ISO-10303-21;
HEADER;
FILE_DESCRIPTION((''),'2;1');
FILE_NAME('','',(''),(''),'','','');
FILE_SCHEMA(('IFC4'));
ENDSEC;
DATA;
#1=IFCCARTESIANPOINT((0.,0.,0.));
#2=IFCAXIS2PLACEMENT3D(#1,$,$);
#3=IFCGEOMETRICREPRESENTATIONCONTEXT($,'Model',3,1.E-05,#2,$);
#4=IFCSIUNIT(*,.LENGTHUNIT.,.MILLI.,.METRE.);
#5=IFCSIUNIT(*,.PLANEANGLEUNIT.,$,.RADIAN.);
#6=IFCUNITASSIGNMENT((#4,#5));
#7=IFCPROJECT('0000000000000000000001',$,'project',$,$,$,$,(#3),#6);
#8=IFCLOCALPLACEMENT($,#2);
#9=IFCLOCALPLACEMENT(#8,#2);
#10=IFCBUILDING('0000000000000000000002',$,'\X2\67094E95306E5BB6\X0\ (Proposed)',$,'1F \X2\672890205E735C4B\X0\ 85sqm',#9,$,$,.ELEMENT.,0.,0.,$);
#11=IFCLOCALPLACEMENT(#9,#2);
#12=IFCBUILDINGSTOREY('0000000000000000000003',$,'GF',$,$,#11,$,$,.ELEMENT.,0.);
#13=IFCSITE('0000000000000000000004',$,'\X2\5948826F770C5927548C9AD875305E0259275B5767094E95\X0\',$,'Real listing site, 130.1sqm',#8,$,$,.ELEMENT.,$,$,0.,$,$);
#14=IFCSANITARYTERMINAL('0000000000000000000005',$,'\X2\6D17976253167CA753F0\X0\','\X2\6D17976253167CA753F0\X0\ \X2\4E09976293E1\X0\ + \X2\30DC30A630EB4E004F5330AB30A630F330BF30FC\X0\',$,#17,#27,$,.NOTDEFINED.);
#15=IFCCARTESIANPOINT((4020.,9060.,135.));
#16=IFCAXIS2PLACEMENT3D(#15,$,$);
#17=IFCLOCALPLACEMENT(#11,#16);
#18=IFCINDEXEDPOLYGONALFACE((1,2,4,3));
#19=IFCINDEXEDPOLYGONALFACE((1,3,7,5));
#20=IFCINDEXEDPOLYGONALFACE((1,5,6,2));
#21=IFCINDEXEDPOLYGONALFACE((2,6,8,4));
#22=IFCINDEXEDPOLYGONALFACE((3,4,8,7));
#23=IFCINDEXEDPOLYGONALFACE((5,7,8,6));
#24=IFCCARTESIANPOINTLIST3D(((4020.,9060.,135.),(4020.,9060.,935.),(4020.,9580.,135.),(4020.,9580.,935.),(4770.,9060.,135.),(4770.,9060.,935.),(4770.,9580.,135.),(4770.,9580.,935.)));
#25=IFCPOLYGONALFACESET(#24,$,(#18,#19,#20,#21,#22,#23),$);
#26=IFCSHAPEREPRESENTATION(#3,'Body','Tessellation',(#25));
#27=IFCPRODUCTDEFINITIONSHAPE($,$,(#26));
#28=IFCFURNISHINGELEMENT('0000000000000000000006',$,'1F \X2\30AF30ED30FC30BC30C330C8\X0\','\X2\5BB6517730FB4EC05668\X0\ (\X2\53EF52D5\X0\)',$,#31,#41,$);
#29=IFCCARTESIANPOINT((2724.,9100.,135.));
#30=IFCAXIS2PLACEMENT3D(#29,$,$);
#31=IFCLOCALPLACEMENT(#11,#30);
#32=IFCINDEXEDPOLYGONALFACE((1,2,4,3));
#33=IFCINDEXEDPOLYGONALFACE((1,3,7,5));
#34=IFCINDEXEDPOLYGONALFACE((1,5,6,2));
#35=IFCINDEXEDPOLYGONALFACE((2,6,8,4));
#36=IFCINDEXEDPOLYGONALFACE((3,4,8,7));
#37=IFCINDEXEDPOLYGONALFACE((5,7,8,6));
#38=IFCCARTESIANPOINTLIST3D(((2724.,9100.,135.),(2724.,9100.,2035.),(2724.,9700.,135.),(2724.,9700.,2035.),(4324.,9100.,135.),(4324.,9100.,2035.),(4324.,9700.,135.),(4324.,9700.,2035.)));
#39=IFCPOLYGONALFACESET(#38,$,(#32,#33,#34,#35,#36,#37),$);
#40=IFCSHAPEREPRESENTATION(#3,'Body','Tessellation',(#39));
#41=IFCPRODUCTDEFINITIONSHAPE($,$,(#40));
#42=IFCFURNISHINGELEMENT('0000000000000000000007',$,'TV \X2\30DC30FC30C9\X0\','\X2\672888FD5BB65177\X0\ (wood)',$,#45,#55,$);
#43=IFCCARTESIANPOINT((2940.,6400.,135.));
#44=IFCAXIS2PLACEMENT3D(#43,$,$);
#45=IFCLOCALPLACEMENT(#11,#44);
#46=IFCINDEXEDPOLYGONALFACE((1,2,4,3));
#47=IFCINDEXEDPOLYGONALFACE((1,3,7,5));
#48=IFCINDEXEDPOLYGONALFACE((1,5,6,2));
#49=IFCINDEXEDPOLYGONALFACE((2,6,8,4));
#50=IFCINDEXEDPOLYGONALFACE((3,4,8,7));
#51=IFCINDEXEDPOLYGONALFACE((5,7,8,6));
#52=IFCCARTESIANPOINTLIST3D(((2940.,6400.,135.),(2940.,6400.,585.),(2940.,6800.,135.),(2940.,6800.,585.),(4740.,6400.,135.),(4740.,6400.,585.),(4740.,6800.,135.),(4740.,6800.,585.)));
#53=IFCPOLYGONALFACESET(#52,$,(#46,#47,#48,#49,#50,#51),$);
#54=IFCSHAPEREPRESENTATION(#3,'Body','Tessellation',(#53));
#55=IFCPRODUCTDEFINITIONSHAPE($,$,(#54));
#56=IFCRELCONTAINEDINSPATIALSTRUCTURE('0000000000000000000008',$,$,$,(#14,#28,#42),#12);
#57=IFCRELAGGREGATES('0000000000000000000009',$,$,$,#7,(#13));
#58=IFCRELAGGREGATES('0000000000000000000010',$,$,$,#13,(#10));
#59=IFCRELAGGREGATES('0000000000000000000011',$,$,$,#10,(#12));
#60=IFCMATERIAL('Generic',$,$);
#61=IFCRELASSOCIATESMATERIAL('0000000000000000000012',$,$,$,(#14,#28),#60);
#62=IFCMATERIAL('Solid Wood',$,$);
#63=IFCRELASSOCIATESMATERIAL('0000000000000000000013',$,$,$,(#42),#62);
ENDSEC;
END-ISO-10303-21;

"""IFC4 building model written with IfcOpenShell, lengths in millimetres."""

from ifc_helpers import new_model, si_unit, frame, frame_2d, origin, place, context, project, spatial, rectangle, extrude, material, element, save


model = new_model("IFC4")

# Units and contexts
model_context = context("Model", 3, precision=1e-05, world=origin())
ifc_project = project(units=[si_unit("LENGTHUNIT", "METRE", prefix="MILLI"), si_unit("PLANEANGLEUNIT", "RADIAN")], contexts=[model_context])

# Site, building, storey
site_placement = place(None, origin())
site = spatial("IfcSite", under=ifc_project, at=site_placement, Name="奈良県大和高田市大字有井", ObjectType="Real listing site, 130.1sqm", CompositionType="ELEMENT", RefElevation=0.0)
building_placement = place(site_placement, origin())
building = spatial("IfcBuilding", under=site, at=building_placement, Name="有井の家 (Proposed)", ObjectType="1F 木造平屋 85sqm", CompositionType="ELEMENT", ElevationOfRefHeight=0.0, ElevationOfTerrain=0.0)
storey_placement = place(building_placement, origin())
storey = spatial("IfcBuildingStorey", under=building, at=storey_placement, Name="GF", CompositionType="ELEMENT", Elevation=0.0)

# Shared definitions
ifc_material_1 = material(Name="Solid Wood")

# Shared definitions
ifc_material_2 = material(Name="Generic")

# Sanitary terminal
sanitary_terminal_1_placement = place(storey_placement, frame((4020.0, 9060.0, 135.0)))
element("IfcSanitaryTerminal", 1, at=sanitary_terminal_1_placement, inside=storey, material=ifc_material_2, Name="洗面化粧台", Description="洗面化粧台 三面鏡 + ボウル一体カウンター", PredefinedType="NOTDEFINED", context=model_context, shape_type="SweptSolid", body=[
    extrude(rectangle(XDim=750.0, YDim=520.0, at=frame_2d((375.0, 260.0))), frame((4020.0, 9060.0, 135.0)), (0.0, 0.0, 1.0), 800.0),
])

# Furnishing elements
furnishing_1_placement = place(storey_placement, frame((2724.0, 9100.0, 135.0)))
element("IfcFurnishingElement", 2, at=furnishing_1_placement, inside=storey, material=ifc_material_2, Name="1F クローゼット", Description="家具・什器 (可動)", context=model_context, shape_type="SweptSolid", body=[
    extrude(rectangle(XDim=1600.0, YDim=600.0, at=frame_2d((800.0, 300.0))), frame((2724.0, 9100.0, 135.0)), (0.0, 0.0, 1.0), 1900.0),
])
furnishing_2_placement = place(storey_placement, frame((2940.0, 6400.0, 135.0)))
element("IfcFurnishingElement", 3, at=furnishing_2_placement, inside=storey, material=ifc_material_1, Name="TV ボード", Description="木製家具 (wood)", context=model_context, shape_type="SweptSolid", body=[
    extrude(rectangle(XDim=1800.0, YDim=400.0, at=frame_2d((900.0, 200.0))), frame((2940.0, 6400.0, 135.0)), (0.0, 0.0, 1.0), 450.0),
])

save(model, "model.ifc")
